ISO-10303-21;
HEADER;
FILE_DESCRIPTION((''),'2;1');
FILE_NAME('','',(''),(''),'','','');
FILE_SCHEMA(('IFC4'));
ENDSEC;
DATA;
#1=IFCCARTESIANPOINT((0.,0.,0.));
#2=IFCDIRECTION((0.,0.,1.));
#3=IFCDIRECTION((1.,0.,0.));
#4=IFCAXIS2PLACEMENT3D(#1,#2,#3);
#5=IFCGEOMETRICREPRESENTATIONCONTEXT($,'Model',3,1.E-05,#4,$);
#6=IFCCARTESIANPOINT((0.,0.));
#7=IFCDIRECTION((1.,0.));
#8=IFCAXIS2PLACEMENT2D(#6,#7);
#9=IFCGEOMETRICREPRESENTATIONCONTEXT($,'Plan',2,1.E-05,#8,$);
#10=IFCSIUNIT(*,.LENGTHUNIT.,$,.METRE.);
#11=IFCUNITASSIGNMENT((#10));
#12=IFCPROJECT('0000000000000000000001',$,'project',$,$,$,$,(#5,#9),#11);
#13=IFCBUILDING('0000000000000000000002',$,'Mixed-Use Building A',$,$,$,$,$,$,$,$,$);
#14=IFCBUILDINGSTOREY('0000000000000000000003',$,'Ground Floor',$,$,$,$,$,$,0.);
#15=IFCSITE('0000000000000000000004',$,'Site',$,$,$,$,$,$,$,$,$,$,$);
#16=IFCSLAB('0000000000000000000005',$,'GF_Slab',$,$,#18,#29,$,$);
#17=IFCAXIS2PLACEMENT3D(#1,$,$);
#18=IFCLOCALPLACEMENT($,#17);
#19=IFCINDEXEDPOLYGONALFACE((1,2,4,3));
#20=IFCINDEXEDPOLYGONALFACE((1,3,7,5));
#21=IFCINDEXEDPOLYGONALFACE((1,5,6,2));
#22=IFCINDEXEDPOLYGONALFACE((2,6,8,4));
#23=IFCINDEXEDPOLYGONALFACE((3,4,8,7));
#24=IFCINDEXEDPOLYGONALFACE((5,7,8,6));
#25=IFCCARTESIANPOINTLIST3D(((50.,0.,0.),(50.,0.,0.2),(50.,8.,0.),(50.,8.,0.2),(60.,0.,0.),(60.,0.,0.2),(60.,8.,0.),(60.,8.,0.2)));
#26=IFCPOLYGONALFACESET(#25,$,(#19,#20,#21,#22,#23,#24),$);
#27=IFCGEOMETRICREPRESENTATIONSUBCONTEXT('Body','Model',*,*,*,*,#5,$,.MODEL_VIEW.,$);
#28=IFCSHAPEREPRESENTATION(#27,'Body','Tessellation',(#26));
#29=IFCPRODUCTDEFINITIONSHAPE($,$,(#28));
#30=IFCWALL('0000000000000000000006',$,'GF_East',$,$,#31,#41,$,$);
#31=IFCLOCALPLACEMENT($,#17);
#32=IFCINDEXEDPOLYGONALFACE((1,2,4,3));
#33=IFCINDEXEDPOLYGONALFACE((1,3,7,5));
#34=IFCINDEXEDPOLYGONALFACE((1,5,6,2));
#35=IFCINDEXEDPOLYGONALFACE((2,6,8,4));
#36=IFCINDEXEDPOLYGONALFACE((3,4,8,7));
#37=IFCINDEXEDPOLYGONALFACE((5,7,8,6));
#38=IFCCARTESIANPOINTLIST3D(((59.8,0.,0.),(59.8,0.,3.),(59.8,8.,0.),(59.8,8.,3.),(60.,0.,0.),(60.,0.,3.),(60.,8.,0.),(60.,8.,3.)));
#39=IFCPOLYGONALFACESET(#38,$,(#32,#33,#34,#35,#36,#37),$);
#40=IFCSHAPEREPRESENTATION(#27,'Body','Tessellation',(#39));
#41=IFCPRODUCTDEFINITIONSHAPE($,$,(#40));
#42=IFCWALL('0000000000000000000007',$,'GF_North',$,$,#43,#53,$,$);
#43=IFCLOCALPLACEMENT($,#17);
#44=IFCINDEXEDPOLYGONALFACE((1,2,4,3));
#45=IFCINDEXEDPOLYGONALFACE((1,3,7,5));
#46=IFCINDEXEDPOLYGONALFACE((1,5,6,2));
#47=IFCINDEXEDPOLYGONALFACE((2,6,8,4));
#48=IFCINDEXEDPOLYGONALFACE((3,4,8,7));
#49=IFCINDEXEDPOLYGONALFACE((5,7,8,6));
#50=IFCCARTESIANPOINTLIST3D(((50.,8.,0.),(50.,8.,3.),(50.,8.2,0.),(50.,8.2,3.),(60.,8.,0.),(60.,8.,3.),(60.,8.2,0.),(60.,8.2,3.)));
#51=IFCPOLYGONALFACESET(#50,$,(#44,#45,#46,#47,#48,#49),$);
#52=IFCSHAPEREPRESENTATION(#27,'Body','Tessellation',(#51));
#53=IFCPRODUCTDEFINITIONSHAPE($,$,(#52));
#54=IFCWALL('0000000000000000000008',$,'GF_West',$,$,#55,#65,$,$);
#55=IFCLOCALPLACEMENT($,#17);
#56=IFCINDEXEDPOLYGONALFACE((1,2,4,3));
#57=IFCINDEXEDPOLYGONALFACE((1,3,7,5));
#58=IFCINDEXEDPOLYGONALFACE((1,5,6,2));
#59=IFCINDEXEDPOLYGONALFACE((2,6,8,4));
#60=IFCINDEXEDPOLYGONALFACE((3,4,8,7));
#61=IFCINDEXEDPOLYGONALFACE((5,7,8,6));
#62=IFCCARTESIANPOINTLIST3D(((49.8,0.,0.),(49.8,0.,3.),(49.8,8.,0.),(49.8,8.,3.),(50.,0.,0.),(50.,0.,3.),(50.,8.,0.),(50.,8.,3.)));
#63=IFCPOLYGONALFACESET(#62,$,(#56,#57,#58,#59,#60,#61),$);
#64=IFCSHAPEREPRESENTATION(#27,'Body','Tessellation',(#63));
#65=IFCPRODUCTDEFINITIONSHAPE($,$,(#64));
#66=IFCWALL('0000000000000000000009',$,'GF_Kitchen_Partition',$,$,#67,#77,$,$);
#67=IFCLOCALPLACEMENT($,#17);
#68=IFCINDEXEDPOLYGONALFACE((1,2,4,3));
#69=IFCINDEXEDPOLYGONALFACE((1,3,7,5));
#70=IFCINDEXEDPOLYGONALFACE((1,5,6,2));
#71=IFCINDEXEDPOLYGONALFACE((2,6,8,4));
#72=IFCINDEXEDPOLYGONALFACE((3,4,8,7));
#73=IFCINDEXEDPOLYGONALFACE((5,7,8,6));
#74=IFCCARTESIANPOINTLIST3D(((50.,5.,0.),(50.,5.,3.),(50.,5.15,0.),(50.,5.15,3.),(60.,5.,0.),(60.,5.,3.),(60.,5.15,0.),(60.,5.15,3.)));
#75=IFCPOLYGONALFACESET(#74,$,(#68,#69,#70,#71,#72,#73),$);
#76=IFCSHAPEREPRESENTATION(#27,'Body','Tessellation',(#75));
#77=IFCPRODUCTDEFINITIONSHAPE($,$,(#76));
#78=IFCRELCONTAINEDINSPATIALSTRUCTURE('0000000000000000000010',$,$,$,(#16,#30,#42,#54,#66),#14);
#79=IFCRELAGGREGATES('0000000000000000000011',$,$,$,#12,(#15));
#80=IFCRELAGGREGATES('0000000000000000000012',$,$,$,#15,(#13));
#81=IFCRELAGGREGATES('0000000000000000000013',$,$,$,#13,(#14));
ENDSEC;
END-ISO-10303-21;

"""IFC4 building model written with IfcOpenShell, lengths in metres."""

from ifc_helpers import new_model, si_unit, frame, origin_with_axes, origin_2d_with_axis, place, context, subcontext, project, spatial, indexed_curve, outline, extrude, element, save


model = new_model("IFC4")

# Units and contexts
model_context = context("Model", 3, precision=1e-05, world=origin_with_axes())
plan_context = context("Plan", 2, precision=1e-05, world=origin_2d_with_axis())
body_context = subcontext(model_context, "Body", "Model", "MODEL_VIEW")
ifc_project = project(units=[si_unit("LENGTHUNIT", "METRE")], contexts=[model_context, plan_context])

# Site, building, storey
site = spatial("IfcSite", under=ifc_project, Name="Site")
building = spatial("IfcBuilding", under=site, Name="Mixed-Use Building A")
storey = spatial("IfcBuildingStorey", under=building, Name="Ground Floor", Elevation=0.0)

# Slab
slab_placement = place(None, frame((50.0, 0.0, 0.0), z_axis=(0.0, 0.0, 1.0), x_axis=(1.0, 0.0, 0.0)))
element("IfcSlab", 1, at=slab_placement, inside=storey, Name="GF_Slab", context=body_context, shape_type="SweptSolid", body=[
    extrude(outline(indexed_curve([(0.0, 0.0), (10.0, 0.0), (10.0, 8.0), (0.0, 8.0)])), None, (0.0, 0.0, 1.0), 0.2),
])

# Walls
wall_1_placement = place(None, frame((60.0, 0.0, 0.0), z_axis=(0.0, 0.0, 1.0), x_axis=(0.0, 1.0, 0.0)))
element("IfcWall", 2, at=wall_1_placement, inside=storey, Name="GF_East", context=body_context, shape_type="SweptSolid", body=[
    extrude(outline(indexed_curve([(0.0, 0.0), (0.0, 0.2), (8.0, 0.2), (8.0, 0.0), (0.0, 0.0)], self_intersect=False)), origin_with_axes(), (0.0, 0.0, 1.0), 3.0),
])
wall_2_placement = place(None, frame((50.0, 8.0, 0.0), z_axis=(0.0, 0.0, 1.0), x_axis=(1.0, 0.0, 0.0)))
element("IfcWall", 3, at=wall_2_placement, inside=storey, Name="GF_North", context=body_context, shape_type="SweptSolid", body=[
    extrude(outline(indexed_curve([(0.0, 0.0), (0.0, 0.2), (10.0, 0.2), (10.0, 0.0), (0.0, 0.0)], self_intersect=False)), origin_with_axes(), (0.0, 0.0, 1.0), 3.0),
])
wall_3_placement = place(None, frame((50.0, 0.0, 0.0), z_axis=(0.0, 0.0, 1.0), x_axis=(0.0, 1.0, 0.0)))
element("IfcWall", 4, at=wall_3_placement, inside=storey, Name="GF_West", context=body_context, shape_type="SweptSolid", body=[
    extrude(outline(indexed_curve([(0.0, 0.0), (0.0, 0.2), (8.0, 0.2), (8.0, 0.0), (0.0, 0.0)], self_intersect=False)), origin_with_axes(), (0.0, 0.0, 1.0), 3.0),
])
wall_4_placement = place(None, frame((50.0, 5.0, 0.0), z_axis=(0.0, 0.0, 1.0), x_axis=(1.0, 0.0, 0.0)))
element("IfcWall", 5, at=wall_4_placement, inside=storey, Name="GF_Kitchen_Partition", context=body_context, shape_type="SweptSolid", body=[
    extrude(outline(indexed_curve([(0.0, 0.0), (0.0, 0.15), (10.0, 0.15), (10.0, 0.0), (0.0, 0.0)], self_intersect=False)), origin_with_axes(), (0.0, 0.0, 1.0), 3.0),
])

save(model, "model.ifc")
